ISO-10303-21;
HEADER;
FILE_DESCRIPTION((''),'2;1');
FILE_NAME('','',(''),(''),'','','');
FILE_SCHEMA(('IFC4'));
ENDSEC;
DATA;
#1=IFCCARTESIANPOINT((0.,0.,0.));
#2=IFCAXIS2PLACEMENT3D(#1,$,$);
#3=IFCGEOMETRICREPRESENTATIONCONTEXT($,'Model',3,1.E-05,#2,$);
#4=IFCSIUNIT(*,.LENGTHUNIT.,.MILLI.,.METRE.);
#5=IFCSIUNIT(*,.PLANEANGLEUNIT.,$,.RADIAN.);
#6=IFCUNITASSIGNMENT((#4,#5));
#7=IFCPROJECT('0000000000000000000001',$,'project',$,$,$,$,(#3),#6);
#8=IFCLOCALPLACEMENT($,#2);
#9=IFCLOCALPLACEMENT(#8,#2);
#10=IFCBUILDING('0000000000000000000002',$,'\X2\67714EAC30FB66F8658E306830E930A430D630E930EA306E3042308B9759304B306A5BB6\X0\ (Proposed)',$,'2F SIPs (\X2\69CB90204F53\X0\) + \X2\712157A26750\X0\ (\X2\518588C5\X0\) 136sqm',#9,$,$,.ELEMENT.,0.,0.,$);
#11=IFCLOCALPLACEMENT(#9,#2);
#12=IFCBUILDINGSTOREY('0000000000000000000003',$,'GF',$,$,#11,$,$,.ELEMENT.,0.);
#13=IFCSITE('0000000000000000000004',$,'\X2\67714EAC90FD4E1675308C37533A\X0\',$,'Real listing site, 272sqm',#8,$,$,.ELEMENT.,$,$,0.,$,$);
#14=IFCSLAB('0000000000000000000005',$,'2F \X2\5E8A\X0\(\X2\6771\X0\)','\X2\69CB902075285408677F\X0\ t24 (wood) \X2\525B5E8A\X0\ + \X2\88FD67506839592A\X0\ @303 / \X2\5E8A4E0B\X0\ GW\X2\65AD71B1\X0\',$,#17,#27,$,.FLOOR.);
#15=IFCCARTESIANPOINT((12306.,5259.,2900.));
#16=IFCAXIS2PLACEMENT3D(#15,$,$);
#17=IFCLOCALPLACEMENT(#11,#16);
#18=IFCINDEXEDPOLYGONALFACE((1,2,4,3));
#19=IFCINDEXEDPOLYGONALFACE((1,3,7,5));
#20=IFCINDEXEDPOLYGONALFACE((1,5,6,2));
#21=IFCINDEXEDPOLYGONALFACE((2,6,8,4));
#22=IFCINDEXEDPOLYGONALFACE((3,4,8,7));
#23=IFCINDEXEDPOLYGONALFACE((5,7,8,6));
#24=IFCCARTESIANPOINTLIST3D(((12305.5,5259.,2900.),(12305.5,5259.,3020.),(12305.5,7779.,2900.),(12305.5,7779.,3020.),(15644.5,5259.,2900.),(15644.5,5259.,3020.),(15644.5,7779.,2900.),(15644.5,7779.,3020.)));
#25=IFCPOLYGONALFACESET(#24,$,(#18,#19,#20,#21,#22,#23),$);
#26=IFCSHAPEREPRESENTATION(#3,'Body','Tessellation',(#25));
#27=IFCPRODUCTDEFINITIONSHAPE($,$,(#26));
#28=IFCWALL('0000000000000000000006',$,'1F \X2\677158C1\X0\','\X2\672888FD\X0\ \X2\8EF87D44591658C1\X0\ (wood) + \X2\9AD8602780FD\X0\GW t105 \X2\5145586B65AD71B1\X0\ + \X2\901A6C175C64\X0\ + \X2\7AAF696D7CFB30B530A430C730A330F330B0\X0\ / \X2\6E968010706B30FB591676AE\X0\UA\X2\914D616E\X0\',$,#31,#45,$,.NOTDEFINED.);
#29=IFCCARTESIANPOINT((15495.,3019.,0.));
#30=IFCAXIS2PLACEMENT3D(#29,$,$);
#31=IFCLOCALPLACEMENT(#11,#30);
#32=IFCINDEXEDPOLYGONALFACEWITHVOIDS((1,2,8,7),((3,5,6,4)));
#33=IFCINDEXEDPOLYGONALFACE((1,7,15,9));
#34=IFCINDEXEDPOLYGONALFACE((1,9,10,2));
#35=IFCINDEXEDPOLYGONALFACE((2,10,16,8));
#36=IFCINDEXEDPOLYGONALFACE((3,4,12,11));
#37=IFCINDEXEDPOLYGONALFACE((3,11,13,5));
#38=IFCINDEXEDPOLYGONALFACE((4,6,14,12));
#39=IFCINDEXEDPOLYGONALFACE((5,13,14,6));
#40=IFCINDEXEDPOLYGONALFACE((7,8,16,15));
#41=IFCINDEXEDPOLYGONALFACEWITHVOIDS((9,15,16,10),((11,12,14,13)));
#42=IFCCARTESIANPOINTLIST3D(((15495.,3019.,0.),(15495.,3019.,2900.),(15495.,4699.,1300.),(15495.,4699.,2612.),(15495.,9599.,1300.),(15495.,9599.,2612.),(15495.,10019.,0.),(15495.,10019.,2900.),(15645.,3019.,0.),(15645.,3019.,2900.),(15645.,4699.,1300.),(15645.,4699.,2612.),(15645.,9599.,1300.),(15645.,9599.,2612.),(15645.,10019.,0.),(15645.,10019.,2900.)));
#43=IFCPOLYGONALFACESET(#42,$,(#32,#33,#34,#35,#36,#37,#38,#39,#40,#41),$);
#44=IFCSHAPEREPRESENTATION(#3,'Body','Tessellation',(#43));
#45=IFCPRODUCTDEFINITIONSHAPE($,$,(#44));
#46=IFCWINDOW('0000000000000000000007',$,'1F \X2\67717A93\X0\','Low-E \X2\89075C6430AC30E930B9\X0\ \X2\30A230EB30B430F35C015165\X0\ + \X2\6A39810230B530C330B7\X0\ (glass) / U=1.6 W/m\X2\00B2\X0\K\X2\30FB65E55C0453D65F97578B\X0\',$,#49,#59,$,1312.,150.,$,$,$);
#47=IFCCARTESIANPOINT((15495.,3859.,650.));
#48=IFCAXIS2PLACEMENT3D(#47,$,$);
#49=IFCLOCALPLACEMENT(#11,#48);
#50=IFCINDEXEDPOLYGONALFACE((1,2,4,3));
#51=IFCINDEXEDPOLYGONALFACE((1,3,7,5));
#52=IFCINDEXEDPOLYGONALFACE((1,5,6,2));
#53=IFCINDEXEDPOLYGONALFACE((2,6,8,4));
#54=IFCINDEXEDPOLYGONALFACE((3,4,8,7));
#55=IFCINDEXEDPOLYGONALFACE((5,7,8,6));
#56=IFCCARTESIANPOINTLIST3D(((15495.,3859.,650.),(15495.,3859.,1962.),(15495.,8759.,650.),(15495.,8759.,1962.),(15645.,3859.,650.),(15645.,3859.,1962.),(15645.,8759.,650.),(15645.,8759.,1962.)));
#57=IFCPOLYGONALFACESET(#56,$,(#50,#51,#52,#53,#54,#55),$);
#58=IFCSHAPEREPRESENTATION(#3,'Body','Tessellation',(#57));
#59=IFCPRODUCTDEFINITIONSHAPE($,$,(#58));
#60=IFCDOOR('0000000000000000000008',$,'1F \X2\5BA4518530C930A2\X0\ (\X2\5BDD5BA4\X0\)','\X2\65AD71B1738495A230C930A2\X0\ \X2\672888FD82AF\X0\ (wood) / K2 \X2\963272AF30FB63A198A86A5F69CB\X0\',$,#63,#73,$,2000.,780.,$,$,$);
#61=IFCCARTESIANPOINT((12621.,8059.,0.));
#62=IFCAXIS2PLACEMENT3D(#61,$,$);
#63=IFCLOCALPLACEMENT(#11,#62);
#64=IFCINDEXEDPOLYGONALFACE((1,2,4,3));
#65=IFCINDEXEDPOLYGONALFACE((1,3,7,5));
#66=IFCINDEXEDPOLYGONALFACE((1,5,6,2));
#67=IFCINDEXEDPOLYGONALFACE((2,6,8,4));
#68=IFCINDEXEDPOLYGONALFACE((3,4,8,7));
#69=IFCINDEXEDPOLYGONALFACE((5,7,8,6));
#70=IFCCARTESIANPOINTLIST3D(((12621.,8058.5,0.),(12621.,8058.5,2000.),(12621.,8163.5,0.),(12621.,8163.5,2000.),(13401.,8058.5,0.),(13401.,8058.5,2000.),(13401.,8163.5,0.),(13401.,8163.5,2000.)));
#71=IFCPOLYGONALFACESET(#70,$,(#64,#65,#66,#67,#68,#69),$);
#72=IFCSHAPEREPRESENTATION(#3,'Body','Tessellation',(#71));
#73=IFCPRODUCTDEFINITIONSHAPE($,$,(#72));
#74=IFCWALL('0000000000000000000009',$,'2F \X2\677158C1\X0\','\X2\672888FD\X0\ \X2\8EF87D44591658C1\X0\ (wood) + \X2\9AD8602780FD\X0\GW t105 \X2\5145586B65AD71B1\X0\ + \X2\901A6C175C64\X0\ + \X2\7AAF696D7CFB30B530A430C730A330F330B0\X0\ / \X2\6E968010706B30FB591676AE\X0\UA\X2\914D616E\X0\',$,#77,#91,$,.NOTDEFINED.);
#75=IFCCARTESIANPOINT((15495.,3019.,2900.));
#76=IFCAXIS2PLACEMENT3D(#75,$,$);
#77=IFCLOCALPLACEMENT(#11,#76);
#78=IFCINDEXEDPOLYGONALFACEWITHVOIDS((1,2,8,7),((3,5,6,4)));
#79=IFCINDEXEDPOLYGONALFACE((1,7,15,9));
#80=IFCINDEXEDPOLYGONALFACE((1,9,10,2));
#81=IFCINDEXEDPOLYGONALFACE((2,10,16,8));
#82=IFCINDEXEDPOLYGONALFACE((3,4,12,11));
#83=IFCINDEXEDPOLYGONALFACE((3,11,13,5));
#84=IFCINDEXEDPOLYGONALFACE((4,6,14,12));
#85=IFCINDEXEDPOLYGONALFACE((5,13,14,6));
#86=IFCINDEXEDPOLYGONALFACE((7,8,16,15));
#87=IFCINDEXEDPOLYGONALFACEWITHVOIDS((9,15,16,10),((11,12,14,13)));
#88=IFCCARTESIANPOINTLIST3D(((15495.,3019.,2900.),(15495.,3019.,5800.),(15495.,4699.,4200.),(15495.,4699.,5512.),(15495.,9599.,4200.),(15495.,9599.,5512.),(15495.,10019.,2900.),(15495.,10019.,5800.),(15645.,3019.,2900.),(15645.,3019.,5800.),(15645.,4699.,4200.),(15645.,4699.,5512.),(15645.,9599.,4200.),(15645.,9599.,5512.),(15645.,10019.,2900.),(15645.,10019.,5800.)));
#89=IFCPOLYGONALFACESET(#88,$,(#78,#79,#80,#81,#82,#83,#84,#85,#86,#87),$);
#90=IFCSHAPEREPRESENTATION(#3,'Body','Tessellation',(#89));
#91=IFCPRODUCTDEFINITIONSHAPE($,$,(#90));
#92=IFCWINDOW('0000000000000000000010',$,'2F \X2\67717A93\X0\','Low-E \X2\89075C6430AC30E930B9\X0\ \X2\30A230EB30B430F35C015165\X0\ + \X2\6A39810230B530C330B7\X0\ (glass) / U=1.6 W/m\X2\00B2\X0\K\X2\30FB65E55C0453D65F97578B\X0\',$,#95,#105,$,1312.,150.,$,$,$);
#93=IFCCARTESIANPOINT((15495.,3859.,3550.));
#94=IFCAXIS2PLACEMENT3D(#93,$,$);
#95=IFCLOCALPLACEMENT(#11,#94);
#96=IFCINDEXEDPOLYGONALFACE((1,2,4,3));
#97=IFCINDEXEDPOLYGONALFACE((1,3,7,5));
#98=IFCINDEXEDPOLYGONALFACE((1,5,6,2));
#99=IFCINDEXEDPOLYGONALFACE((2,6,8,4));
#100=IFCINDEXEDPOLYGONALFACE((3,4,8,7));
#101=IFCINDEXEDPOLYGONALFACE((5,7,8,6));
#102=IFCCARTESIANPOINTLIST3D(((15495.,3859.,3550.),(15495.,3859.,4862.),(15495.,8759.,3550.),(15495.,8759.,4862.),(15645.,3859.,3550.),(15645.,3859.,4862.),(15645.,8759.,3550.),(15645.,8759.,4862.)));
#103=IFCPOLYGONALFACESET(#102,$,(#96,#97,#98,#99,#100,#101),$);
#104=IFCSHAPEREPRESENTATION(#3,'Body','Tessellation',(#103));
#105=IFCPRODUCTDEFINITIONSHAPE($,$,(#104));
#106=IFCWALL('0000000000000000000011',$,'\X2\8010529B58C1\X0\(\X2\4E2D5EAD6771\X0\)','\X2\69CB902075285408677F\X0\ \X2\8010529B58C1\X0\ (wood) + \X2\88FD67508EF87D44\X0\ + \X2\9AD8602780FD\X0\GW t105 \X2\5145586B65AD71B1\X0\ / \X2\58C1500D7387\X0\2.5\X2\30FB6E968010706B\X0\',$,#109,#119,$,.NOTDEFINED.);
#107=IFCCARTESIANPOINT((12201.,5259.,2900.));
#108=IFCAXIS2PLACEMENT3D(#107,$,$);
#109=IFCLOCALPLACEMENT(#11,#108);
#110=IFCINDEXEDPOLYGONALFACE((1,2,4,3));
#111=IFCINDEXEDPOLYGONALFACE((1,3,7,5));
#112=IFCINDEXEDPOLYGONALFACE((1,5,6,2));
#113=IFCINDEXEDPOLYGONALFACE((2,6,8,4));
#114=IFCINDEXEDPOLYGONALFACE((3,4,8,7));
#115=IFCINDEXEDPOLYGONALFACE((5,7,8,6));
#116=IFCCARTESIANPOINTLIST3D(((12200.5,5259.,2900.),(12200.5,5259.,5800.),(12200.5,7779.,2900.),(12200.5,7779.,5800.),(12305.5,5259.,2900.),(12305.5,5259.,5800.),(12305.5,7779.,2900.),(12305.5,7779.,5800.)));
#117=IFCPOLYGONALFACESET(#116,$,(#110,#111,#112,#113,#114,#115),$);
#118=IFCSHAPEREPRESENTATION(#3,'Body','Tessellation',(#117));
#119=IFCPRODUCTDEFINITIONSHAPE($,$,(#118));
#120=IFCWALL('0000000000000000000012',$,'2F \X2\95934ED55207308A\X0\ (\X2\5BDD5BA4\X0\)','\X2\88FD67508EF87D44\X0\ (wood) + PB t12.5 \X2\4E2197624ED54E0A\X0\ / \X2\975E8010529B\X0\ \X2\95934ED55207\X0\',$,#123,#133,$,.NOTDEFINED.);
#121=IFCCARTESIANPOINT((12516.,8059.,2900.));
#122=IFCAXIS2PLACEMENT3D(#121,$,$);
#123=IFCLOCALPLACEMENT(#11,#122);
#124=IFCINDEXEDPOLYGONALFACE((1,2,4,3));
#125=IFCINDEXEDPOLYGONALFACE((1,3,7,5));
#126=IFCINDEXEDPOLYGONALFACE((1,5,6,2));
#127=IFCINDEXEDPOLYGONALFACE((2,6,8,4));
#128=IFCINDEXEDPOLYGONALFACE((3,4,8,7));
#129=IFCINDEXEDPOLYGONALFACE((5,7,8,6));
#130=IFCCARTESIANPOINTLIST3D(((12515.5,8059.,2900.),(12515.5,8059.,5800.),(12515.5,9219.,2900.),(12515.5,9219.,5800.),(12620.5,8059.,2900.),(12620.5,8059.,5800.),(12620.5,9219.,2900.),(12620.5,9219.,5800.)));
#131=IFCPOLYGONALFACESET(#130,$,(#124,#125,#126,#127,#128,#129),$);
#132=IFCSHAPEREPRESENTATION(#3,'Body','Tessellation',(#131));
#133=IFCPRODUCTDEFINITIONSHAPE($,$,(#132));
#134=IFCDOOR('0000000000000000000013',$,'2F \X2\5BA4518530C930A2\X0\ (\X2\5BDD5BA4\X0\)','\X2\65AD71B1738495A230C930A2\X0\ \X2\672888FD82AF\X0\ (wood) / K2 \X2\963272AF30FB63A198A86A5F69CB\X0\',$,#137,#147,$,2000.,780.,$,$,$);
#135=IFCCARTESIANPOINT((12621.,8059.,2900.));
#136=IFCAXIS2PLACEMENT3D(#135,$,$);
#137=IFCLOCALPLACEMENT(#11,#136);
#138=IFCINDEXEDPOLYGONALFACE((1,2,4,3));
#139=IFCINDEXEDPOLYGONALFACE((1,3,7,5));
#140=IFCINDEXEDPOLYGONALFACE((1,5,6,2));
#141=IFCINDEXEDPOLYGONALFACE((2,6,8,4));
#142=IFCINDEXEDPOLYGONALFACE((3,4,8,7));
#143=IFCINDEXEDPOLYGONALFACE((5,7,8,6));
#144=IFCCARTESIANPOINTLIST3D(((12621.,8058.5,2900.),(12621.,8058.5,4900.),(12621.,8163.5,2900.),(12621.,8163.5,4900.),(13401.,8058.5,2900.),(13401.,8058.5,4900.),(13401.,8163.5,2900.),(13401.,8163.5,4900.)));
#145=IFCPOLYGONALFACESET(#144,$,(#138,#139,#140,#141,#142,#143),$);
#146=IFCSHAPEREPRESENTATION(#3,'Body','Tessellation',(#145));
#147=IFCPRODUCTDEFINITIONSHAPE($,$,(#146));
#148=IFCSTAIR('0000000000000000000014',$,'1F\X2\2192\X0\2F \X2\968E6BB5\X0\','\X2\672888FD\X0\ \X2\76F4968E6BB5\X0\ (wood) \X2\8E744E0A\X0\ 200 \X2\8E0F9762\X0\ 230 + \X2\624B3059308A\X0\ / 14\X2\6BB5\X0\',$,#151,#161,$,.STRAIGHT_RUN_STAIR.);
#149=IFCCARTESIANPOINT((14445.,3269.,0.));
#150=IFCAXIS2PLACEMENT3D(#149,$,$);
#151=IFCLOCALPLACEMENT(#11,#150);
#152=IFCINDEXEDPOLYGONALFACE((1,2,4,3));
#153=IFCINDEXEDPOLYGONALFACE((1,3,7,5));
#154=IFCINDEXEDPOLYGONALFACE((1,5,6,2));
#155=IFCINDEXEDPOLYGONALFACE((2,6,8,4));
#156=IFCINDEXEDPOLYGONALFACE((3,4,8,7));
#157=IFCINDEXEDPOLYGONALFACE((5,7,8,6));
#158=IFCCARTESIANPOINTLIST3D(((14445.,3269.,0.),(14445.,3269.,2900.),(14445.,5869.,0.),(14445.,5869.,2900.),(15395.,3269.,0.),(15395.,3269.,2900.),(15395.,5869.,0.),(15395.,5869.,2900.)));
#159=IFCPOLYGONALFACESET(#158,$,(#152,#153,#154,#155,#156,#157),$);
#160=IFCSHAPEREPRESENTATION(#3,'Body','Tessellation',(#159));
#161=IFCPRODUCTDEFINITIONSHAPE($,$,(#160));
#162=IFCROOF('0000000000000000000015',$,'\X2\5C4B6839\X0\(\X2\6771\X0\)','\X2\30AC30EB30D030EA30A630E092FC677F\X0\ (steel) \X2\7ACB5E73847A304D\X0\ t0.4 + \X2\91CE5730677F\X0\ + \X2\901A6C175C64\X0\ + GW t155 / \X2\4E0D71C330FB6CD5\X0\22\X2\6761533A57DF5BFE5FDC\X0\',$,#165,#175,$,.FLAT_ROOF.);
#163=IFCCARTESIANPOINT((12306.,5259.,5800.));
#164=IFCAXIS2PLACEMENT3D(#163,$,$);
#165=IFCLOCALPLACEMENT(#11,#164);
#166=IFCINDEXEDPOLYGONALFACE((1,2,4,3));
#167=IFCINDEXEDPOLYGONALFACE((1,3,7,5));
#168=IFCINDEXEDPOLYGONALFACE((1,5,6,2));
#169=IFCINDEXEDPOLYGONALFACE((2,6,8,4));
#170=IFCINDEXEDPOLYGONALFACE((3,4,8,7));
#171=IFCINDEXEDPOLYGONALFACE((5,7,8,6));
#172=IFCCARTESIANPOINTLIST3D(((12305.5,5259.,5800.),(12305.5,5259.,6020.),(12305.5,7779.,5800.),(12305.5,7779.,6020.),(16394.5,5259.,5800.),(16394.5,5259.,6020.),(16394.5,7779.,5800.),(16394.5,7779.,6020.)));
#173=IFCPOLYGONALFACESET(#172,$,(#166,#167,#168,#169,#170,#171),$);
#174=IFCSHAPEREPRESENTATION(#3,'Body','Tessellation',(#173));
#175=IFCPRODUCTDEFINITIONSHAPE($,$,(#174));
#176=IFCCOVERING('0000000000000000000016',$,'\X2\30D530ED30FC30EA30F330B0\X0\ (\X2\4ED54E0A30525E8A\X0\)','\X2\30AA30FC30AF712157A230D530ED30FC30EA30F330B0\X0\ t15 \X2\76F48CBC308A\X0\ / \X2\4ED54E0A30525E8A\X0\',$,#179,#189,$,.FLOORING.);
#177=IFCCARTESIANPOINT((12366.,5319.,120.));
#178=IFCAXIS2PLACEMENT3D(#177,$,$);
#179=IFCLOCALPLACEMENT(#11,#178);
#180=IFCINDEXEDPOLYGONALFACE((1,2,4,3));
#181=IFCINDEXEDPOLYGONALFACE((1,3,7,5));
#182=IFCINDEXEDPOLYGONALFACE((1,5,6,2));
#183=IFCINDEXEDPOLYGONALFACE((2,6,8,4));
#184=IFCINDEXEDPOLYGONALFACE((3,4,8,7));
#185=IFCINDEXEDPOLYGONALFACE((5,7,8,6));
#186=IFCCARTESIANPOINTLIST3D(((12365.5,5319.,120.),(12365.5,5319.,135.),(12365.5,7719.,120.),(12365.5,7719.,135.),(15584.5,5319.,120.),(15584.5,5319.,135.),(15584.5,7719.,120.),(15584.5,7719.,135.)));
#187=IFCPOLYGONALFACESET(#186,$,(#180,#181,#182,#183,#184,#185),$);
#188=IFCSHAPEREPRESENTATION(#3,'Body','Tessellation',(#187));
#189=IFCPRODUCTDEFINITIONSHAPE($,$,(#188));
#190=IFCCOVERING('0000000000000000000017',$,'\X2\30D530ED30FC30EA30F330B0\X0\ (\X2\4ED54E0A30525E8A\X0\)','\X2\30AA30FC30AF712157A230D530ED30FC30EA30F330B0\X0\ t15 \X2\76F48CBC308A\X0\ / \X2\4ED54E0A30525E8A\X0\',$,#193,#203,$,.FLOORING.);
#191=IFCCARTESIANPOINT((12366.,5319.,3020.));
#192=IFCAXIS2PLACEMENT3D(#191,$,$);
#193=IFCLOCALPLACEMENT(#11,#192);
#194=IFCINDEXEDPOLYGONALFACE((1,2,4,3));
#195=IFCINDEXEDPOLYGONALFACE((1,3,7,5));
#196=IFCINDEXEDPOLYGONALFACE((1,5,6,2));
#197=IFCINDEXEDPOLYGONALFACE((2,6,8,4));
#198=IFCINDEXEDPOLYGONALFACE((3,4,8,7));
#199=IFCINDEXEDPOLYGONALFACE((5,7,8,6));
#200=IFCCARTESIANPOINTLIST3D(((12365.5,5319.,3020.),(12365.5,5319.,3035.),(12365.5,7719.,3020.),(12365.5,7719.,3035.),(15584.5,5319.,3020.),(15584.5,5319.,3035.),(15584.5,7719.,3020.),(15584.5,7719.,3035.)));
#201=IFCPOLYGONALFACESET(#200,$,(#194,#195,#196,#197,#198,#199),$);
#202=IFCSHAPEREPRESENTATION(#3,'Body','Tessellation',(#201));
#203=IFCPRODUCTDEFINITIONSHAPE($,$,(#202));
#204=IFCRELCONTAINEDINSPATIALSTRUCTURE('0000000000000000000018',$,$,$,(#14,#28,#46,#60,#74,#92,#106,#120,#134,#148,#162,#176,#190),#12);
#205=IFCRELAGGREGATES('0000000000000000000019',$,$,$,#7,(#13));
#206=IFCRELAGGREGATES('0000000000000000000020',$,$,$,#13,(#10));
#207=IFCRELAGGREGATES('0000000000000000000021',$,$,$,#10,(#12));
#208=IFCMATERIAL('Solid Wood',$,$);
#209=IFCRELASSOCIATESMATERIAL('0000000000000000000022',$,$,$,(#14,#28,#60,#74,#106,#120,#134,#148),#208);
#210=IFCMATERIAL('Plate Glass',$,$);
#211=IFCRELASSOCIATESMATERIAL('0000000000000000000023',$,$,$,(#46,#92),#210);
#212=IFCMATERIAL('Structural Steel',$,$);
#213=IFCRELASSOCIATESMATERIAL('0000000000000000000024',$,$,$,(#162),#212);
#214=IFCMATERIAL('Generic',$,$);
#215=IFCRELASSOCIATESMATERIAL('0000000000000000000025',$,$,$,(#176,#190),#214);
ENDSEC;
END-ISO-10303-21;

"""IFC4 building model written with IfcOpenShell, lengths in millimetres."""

from ifc_helpers import new_model, si_unit, frame, frame_2d, origin, place, context, project, spatial, rectangle, extrude, material, element, fill, save


model = new_model("IFC4")

# Units and contexts
model_context = context("Model", 3, precision=1e-05, world=origin())
ifc_project = project(units=[si_unit("LENGTHUNIT", "METRE", prefix="MILLI"), si_unit("PLANEANGLEUNIT", "RADIAN")], contexts=[model_context])

# Site, building, storey
site_placement = place(None, origin())
site = spatial("IfcSite", under=ifc_project, at=site_placement, Name="東京都世田谷区", ObjectType="Real listing site, 272sqm", CompositionType="ELEMENT", RefElevation=0.0)
building_placement = place(site_placement, origin())
building = spatial("IfcBuilding", under=site, at=building_placement, Name="東京・書斎とライブラリのある静かな家 (Proposed)", ObjectType="2F SIPs (構造体) + 無垢材 (内装) 136sqm", CompositionType="ELEMENT", ElevationOfRefHeight=0.0, ElevationOfTerrain=0.0)
storey_placement = place(building_placement, origin())
storey = spatial("IfcBuildingStorey", under=building, at=storey_placement, Name="GF", CompositionType="ELEMENT", Elevation=0.0)

# Slab
ifc_material_1 = material(Name="Solid Wood")
slab_1_placement = place(storey_placement, frame((12306.0, 5259.0, 2900.0)))
element("IfcSlab", 1, at=slab_1_placement, inside=storey, material=ifc_material_1, Name="2F 床(東)", Description="構造用合板 t24 (wood) 剛床 + 製材根太 @303 / 床下 GW断熱", PredefinedType="FLOOR", context=model_context, shape_type="SweptSolid", body=[
    extrude(rectangle(XDim=3339.0, YDim=2520.0, at=frame_2d((1669.0, 1260.0))), frame((12306.0, 5259.0, 2900.0)), (0.0, 0.0, 1.0), 120.0),
])

# Wall, opening, window
wall_1_placement = place(storey_placement, frame((15495.0, 3019.0, 0.0)))
wall_1 = element("IfcWall", 2, at=wall_1_placement, inside=storey, material=ifc_material_1, Name="1F 東壁", Description="木製 軸組外壁 (wood) + 高性能GW t105 充填断熱 + 通気層 + 窯業系サイディング / 準耐火・外皮UA配慮", PredefinedType="NOTDEFINED", context=model_context, shape_type="SweptSolid", body=[
    extrude(rectangle(XDim=150.0, YDim=7000.0, at=frame_2d((75.0, 3500.0))), frame((15495.0, 3019.0, 0.0)), (0.0, 0.0, 1.0), 2900.0),
])
opening_1_placement = place(storey_placement, frame((15495.0, 3859.0, 650.0)))
opening_1 = element("IfcOpeningElement", 3, at=opening_1_placement, cuts=wall_1, PredefinedType="NOTDEFINED", context=model_context, shape_type="SweptSolid", body=[
    extrude(rectangle(XDim=150.0, YDim=4900.0, at=frame_2d((75.0, 2450.0))), frame((15495.0, 3859.0, 650.0)), (0.0, 0.0, 1.0), 1312.0),
])
ifc_material_2 = material(Name="Plate Glass")
window_1_placement = place(storey_placement, frame((15495.0, 3859.0, 650.0)))
window_1 = element("IfcWindow", 4, at=window_1_placement, inside=storey, material=ifc_material_2, Name="1F 東窓", Description="Low-E 複層ガラス アルゴン封入 + 樹脂サッシ (glass) / U=1.6 W/m²K・日射取得型", OverallHeight=1312.0, OverallWidth=150.0, context=model_context, shape_type="SweptSolid", body=[
    extrude(rectangle(XDim=150.0, YDim=4900.0, at=frame_2d((75.0, 2450.0))), frame((15495.0, 3859.0, 650.0)), (0.0, 0.0, 1.0), 1312.0),
])
fill(opening_1, window_1)

# Door
door_1_placement = place(storey_placement, frame((12621.0, 8059.0, 0.0)))
element("IfcDoor", 5, at=door_1_placement, inside=storey, material=ifc_material_1, Name="1F 室内ドア (寝室)", Description="断熱玄関ドア 木製芯 (wood) / K2 防犯・採風機構", OverallHeight=2000.0, OverallWidth=780.0, context=model_context, shape_type="SweptSolid", body=[
    extrude(rectangle(XDim=780.0, YDim=105.0, at=frame_2d((390.0, 52.0))), frame((12621.0, 8059.0, 0.0)), (0.0, 0.0, 1.0), 2000.0),
])

# Wall, opening, window
wall_2_placement = place(storey_placement, frame((15495.0, 3019.0, 2900.0)))
wall_2 = element("IfcWall", 6, at=wall_2_placement, inside=storey, material=ifc_material_1, Name="2F 東壁", Description="木製 軸組外壁 (wood) + 高性能GW t105 充填断熱 + 通気層 + 窯業系サイディング / 準耐火・外皮UA配慮", PredefinedType="NOTDEFINED", context=model_context, shape_type="SweptSolid", body=[
    extrude(rectangle(XDim=150.0, YDim=7000.0, at=frame_2d((75.0, 3500.0))), frame((15495.0, 3019.0, 2900.0)), (0.0, 0.0, 1.0), 2900.0),
])
opening_2_placement = place(storey_placement, frame((15495.0, 3859.0, 3550.0)))
opening_2 = element("IfcOpeningElement", 7, at=opening_2_placement, cuts=wall_2, PredefinedType="NOTDEFINED", context=model_context, shape_type="SweptSolid", body=[
    extrude(rectangle(XDim=150.0, YDim=4900.0, at=frame_2d((75.0, 2450.0))), frame((15495.0, 3859.0, 3550.0)), (0.0, 0.0, 1.0), 1312.0),
])
window_2_placement = place(storey_placement, frame((15495.0, 3859.0, 3550.0)))
window_2 = element("IfcWindow", 8, at=window_2_placement, inside=storey, material=ifc_material_2, Name="2F 東窓", Description="Low-E 複層ガラス アルゴン封入 + 樹脂サッシ (glass) / U=1.6 W/m²K・日射取得型", OverallHeight=1312.0, OverallWidth=150.0, context=model_context, shape_type="SweptSolid", body=[
    extrude(rectangle(XDim=150.0, YDim=4900.0, at=frame_2d((75.0, 2450.0))), frame((15495.0, 3859.0, 3550.0)), (0.0, 0.0, 1.0), 1312.0),
])
fill(opening_2, window_2)

# Walls
wall_3_placement = place(storey_placement, frame((12201.0, 5259.0, 2900.0)))
element("IfcWall", 9, at=wall_3_placement, inside=storey, material=ifc_material_1, Name="耐力壁(中庭東)", Description="構造用合板 耐力壁 (wood) + 製材軸組 + 高性能GW t105 充填断熱 / 壁倍率2.5・準耐火", PredefinedType="NOTDEFINED", context=model_context, shape_type="SweptSolid", body=[
    extrude(rectangle(XDim=105.0, YDim=2520.0, at=frame_2d((52.0, 1260.0))), frame((12201.0, 5259.0, 2900.0)), (0.0, 0.0, 1.0), 2900.0),
])
wall_4_placement = place(storey_placement, frame((12516.0, 8059.0, 2900.0)))
element("IfcWall", 10, at=wall_4_placement, inside=storey, material=ifc_material_1, Name="2F 間仕切り (寝室)", Description="製材軸組 (wood) + PB t12.5 両面仕上 / 非耐力 間仕切", PredefinedType="NOTDEFINED", context=model_context, shape_type="SweptSolid", body=[
    extrude(rectangle(XDim=105.0, YDim=1160.0, at=frame_2d((52.0, 580.0))), frame((12516.0, 8059.0, 2900.0)), (0.0, 0.0, 1.0), 2900.0),
])

# Door
door_2_placement = place(storey_placement, frame((12621.0, 8059.0, 2900.0)))
element("IfcDoor", 11, at=door_2_placement, inside=storey, material=ifc_material_1, Name="2F 室内ドア (寝室)", Description="断熱玄関ドア 木製芯 (wood) / K2 防犯・採風機構", OverallHeight=2000.0, OverallWidth=780.0, context=model_context, shape_type="SweptSolid", body=[
    extrude(rectangle(XDim=780.0, YDim=105.0, at=frame_2d((390.0, 52.0))), frame((12621.0, 8059.0, 2900.0)), (0.0, 0.0, 1.0), 2000.0),
])

# Stair
stair_placement = place(storey_placement, frame((14445.0, 3269.0, 0.0)))
element("IfcStair", 12, at=stair_placement, inside=storey, material=ifc_material_1, Name="1F→2F 階段", Description="木製 直階段 (wood) 蹴上 200 踏面 230 + 手すり / 14段", PredefinedType="STRAIGHT_RUN_STAIR", context=model_context, shape_type="SweptSolid", body=[
    extrude(rectangle(XDim=950.0, YDim=2600.0, at=frame_2d((475.0, 1300.0))), frame((14445.0, 3269.0, 0.0)), (0.0, 0.0, 1.0), 2900.0),
])

# Roof
ifc_material_3 = material(Name="Structural Steel")
for number, where, name in (
    (13, (12306.0, 5259.0, 5800.0), "屋根(東)"),
):
    element("IfcRoof", number, at=place(storey_placement, frame(where)), inside=storey, material=ifc_material_3, Name=name, Description="ガルバリウム鋼板 (steel) 立平葺き t0.4 + 野地板 + 通気層 + GW t155 / 不燃・法22条区域対応", PredefinedType="FLAT_ROOF", context=model_context, shape_type="SweptSolid", body=[
        extrude(rectangle(XDim=4089.0, YDim=2520.0, at=frame_2d((2044.0, 1260.0))), frame((12306.0, 5259.0, 5800.0)), (0.0, 0.0, 1.0), 220.0),
    ])

# Coverings
ifc_material_4 = material(Name="Generic")
covering_1_placement = place(storey_placement, frame((12366.0, 5319.0, 120.0)))
element("IfcCovering", 14, at=covering_1_placement, inside=storey, material=ifc_material_4, Name="フローリング (仕上げ床)", Description="オーク無垢フローリング t15 直貼り / 仕上げ床", PredefinedType="FLOORING", context=model_context, shape_type="SweptSolid", body=[
    extrude(rectangle(XDim=3219.0, YDim=2400.0, at=frame_2d((1609.0, 1200.0))), frame((12366.0, 5319.0, 120.0)), (0.0, 0.0, 1.0), 15.0),
])
covering_2_placement = place(storey_placement, frame((12366.0, 5319.0, 3020.0)))
element("IfcCovering", 15, at=covering_2_placement, inside=storey, material=ifc_material_4, Name="フローリング (仕上げ床)", Description="オーク無垢フローリング t15 直貼り / 仕上げ床", PredefinedType="FLOORING", context=model_context, shape_type="SweptSolid", body=[
    extrude(rectangle(XDim=3219.0, YDim=2400.0, at=frame_2d((1609.0, 1200.0))), frame((12366.0, 5319.0, 3020.0)), (0.0, 0.0, 1.0), 15.0),
])

save(model, "model.ifc")
